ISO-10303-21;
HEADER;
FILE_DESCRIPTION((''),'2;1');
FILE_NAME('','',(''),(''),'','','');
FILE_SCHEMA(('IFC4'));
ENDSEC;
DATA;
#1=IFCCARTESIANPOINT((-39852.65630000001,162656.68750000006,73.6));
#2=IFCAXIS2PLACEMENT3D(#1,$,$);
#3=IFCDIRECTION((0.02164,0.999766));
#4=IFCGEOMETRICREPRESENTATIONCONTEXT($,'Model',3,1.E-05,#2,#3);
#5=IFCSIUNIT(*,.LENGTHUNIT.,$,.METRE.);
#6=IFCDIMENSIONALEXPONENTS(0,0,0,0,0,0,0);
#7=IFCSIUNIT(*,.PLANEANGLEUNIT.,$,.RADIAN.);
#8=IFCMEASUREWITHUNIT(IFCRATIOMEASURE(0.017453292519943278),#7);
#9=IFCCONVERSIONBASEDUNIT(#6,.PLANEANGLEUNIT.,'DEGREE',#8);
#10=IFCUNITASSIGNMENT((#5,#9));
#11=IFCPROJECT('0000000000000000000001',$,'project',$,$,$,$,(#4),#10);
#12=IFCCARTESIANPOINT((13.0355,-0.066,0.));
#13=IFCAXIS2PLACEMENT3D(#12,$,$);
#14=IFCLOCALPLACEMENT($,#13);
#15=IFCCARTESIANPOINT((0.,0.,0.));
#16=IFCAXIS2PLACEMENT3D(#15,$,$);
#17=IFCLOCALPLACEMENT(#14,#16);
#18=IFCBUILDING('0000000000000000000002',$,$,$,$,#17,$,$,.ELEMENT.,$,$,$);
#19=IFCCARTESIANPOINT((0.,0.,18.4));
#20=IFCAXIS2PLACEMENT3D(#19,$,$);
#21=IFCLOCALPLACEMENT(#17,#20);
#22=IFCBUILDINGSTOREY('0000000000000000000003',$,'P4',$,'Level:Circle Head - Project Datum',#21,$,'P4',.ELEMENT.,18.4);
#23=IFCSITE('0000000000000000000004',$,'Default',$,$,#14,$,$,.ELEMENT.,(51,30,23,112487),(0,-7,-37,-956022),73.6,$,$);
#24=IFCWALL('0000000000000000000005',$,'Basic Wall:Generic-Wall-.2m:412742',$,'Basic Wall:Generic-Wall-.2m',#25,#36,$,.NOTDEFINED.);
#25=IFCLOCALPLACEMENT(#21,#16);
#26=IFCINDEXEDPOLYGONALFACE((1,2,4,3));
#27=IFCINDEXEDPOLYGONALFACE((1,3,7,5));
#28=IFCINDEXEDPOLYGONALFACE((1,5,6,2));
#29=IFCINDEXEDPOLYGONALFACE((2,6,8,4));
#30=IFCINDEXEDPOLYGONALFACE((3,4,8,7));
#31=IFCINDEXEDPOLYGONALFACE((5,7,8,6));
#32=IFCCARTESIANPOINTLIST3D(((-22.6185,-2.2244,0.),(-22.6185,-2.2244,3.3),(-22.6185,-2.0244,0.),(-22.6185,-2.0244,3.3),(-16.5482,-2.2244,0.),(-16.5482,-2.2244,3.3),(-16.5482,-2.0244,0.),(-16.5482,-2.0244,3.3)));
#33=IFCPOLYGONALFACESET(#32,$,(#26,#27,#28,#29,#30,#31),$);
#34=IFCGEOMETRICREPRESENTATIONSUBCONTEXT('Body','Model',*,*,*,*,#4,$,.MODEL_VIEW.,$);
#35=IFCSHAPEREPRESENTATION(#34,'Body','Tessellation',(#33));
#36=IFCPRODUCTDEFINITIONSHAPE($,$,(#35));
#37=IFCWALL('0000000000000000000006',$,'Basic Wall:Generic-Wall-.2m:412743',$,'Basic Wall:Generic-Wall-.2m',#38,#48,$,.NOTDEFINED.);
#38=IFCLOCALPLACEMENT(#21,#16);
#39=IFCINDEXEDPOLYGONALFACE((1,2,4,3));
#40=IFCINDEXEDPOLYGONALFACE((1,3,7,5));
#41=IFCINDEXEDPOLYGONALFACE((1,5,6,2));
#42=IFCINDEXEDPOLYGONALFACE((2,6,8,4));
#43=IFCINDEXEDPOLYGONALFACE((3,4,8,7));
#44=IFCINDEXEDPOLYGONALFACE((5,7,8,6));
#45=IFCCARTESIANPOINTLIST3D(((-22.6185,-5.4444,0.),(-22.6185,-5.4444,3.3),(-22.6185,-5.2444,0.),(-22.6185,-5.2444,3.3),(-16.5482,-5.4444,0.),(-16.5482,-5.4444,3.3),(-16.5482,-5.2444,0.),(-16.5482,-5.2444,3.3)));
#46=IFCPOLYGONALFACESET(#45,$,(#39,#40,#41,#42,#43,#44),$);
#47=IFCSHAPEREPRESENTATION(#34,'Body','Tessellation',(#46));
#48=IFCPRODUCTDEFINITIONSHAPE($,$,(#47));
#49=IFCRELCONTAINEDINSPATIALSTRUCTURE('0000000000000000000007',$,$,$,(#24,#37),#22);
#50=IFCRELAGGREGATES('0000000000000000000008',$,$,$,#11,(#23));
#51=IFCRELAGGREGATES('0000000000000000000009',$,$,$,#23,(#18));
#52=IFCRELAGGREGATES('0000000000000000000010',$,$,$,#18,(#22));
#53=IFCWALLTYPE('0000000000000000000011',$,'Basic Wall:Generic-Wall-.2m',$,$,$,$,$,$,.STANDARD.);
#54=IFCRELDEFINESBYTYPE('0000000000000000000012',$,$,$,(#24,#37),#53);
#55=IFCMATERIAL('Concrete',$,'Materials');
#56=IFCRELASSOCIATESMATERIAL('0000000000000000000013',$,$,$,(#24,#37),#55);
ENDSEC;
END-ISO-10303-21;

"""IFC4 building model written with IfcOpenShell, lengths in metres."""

from ifc_helpers import new_model, entity, si_unit, converted_unit, direction, frame, origin, place, context, subcontext, project, spatial, indexed_curve, outline, extrude, material, type_object, element, save


model = new_model("IFC4")

# Units and contexts
model_context = context("Model", 3, precision=1e-05, world=frame((-39852.65630000001, 162656.68750000006, 73.6)), true_north=direction((0.02164, 0.999766)))
body_context = subcontext(model_context, "Body", "Model", "MODEL_VIEW")
ifc_project = project(units=[si_unit("LENGTHUNIT", "METRE"), converted_unit("PLANEANGLEUNIT", "DEGREE", entity("IfcRatioMeasure", 0.017453292519943278), si_unit("PLANEANGLEUNIT", "RADIAN"), dimensions=[0, 0, 0, 0, 0, 0, 0])], contexts=[model_context])

# Site, building, storey
site_placement = place(None, frame((13.0355, -0.066, 0.0)))
site = spatial("IfcSite", under=ifc_project, at=site_placement, Name="Default", CompositionType="ELEMENT", RefLatitude=(51, 30, 23, 112487), RefLongitude=(0, -7, -37, -956022), RefElevation=73.6)
building_placement = place(site_placement, origin())
building = spatial("IfcBuilding", under=site, at=building_placement, CompositionType="ELEMENT")
storey_placement = place(building_placement, frame((0.0, 0.0, 18.4)))
storey = spatial("IfcBuildingStorey", under=building, at=storey_placement, Name="P4", ObjectType="Level:Circle Head - Project Datum", LongName="P4", CompositionType="ELEMENT", Elevation=18.4)

# Shared definitions
ifc_material = material(Name="Concrete", Category="Materials")

# Walls
wall_type_1 = type_object("IfcWallType", Name="Basic Wall:Generic-Wall-.2m", PredefinedType="STANDARD")
wall_1_placement = place(storey_placement, frame((-22.6185, -2.1244, 0.0)))
element("IfcWall", 1, at=wall_1_placement, inside=storey, type_object=wall_type_1, material=ifc_material, Name="Basic Wall:Generic-Wall-.2m:412742", ObjectType="Basic Wall:Generic-Wall-.2m", PredefinedType="NOTDEFINED", context=body_context, shape_type="SweptSolid", body=[
    extrude(outline(indexed_curve([(6.0702, 0.1), (0.0, 0.1), (0.0, -0.1), (6.0702, -0.1), (6.0702, 0.1)], self_intersect=False)), origin(), (0.0, 0.0, 1.0), 3.3),
])
wall_2_placement = place(storey_placement, frame((-22.6185, -5.3444, 0.0)))
element("IfcWall", 2, at=wall_2_placement, inside=storey, type_object=wall_type_1, material=ifc_material, Name="Basic Wall:Generic-Wall-.2m:412743", ObjectType="Basic Wall:Generic-Wall-.2m", PredefinedType="NOTDEFINED", context=body_context, shape_type="SweptSolid", body=[
    extrude(outline(indexed_curve([(6.0702, 0.1), (0.0, 0.1), (0.0, -0.1), (6.0702, -0.1), (6.0702, 0.1)], self_intersect=False)), origin(), (0.0, 0.0, 1.0), 3.3),
])

save(model, "model.ifc")
